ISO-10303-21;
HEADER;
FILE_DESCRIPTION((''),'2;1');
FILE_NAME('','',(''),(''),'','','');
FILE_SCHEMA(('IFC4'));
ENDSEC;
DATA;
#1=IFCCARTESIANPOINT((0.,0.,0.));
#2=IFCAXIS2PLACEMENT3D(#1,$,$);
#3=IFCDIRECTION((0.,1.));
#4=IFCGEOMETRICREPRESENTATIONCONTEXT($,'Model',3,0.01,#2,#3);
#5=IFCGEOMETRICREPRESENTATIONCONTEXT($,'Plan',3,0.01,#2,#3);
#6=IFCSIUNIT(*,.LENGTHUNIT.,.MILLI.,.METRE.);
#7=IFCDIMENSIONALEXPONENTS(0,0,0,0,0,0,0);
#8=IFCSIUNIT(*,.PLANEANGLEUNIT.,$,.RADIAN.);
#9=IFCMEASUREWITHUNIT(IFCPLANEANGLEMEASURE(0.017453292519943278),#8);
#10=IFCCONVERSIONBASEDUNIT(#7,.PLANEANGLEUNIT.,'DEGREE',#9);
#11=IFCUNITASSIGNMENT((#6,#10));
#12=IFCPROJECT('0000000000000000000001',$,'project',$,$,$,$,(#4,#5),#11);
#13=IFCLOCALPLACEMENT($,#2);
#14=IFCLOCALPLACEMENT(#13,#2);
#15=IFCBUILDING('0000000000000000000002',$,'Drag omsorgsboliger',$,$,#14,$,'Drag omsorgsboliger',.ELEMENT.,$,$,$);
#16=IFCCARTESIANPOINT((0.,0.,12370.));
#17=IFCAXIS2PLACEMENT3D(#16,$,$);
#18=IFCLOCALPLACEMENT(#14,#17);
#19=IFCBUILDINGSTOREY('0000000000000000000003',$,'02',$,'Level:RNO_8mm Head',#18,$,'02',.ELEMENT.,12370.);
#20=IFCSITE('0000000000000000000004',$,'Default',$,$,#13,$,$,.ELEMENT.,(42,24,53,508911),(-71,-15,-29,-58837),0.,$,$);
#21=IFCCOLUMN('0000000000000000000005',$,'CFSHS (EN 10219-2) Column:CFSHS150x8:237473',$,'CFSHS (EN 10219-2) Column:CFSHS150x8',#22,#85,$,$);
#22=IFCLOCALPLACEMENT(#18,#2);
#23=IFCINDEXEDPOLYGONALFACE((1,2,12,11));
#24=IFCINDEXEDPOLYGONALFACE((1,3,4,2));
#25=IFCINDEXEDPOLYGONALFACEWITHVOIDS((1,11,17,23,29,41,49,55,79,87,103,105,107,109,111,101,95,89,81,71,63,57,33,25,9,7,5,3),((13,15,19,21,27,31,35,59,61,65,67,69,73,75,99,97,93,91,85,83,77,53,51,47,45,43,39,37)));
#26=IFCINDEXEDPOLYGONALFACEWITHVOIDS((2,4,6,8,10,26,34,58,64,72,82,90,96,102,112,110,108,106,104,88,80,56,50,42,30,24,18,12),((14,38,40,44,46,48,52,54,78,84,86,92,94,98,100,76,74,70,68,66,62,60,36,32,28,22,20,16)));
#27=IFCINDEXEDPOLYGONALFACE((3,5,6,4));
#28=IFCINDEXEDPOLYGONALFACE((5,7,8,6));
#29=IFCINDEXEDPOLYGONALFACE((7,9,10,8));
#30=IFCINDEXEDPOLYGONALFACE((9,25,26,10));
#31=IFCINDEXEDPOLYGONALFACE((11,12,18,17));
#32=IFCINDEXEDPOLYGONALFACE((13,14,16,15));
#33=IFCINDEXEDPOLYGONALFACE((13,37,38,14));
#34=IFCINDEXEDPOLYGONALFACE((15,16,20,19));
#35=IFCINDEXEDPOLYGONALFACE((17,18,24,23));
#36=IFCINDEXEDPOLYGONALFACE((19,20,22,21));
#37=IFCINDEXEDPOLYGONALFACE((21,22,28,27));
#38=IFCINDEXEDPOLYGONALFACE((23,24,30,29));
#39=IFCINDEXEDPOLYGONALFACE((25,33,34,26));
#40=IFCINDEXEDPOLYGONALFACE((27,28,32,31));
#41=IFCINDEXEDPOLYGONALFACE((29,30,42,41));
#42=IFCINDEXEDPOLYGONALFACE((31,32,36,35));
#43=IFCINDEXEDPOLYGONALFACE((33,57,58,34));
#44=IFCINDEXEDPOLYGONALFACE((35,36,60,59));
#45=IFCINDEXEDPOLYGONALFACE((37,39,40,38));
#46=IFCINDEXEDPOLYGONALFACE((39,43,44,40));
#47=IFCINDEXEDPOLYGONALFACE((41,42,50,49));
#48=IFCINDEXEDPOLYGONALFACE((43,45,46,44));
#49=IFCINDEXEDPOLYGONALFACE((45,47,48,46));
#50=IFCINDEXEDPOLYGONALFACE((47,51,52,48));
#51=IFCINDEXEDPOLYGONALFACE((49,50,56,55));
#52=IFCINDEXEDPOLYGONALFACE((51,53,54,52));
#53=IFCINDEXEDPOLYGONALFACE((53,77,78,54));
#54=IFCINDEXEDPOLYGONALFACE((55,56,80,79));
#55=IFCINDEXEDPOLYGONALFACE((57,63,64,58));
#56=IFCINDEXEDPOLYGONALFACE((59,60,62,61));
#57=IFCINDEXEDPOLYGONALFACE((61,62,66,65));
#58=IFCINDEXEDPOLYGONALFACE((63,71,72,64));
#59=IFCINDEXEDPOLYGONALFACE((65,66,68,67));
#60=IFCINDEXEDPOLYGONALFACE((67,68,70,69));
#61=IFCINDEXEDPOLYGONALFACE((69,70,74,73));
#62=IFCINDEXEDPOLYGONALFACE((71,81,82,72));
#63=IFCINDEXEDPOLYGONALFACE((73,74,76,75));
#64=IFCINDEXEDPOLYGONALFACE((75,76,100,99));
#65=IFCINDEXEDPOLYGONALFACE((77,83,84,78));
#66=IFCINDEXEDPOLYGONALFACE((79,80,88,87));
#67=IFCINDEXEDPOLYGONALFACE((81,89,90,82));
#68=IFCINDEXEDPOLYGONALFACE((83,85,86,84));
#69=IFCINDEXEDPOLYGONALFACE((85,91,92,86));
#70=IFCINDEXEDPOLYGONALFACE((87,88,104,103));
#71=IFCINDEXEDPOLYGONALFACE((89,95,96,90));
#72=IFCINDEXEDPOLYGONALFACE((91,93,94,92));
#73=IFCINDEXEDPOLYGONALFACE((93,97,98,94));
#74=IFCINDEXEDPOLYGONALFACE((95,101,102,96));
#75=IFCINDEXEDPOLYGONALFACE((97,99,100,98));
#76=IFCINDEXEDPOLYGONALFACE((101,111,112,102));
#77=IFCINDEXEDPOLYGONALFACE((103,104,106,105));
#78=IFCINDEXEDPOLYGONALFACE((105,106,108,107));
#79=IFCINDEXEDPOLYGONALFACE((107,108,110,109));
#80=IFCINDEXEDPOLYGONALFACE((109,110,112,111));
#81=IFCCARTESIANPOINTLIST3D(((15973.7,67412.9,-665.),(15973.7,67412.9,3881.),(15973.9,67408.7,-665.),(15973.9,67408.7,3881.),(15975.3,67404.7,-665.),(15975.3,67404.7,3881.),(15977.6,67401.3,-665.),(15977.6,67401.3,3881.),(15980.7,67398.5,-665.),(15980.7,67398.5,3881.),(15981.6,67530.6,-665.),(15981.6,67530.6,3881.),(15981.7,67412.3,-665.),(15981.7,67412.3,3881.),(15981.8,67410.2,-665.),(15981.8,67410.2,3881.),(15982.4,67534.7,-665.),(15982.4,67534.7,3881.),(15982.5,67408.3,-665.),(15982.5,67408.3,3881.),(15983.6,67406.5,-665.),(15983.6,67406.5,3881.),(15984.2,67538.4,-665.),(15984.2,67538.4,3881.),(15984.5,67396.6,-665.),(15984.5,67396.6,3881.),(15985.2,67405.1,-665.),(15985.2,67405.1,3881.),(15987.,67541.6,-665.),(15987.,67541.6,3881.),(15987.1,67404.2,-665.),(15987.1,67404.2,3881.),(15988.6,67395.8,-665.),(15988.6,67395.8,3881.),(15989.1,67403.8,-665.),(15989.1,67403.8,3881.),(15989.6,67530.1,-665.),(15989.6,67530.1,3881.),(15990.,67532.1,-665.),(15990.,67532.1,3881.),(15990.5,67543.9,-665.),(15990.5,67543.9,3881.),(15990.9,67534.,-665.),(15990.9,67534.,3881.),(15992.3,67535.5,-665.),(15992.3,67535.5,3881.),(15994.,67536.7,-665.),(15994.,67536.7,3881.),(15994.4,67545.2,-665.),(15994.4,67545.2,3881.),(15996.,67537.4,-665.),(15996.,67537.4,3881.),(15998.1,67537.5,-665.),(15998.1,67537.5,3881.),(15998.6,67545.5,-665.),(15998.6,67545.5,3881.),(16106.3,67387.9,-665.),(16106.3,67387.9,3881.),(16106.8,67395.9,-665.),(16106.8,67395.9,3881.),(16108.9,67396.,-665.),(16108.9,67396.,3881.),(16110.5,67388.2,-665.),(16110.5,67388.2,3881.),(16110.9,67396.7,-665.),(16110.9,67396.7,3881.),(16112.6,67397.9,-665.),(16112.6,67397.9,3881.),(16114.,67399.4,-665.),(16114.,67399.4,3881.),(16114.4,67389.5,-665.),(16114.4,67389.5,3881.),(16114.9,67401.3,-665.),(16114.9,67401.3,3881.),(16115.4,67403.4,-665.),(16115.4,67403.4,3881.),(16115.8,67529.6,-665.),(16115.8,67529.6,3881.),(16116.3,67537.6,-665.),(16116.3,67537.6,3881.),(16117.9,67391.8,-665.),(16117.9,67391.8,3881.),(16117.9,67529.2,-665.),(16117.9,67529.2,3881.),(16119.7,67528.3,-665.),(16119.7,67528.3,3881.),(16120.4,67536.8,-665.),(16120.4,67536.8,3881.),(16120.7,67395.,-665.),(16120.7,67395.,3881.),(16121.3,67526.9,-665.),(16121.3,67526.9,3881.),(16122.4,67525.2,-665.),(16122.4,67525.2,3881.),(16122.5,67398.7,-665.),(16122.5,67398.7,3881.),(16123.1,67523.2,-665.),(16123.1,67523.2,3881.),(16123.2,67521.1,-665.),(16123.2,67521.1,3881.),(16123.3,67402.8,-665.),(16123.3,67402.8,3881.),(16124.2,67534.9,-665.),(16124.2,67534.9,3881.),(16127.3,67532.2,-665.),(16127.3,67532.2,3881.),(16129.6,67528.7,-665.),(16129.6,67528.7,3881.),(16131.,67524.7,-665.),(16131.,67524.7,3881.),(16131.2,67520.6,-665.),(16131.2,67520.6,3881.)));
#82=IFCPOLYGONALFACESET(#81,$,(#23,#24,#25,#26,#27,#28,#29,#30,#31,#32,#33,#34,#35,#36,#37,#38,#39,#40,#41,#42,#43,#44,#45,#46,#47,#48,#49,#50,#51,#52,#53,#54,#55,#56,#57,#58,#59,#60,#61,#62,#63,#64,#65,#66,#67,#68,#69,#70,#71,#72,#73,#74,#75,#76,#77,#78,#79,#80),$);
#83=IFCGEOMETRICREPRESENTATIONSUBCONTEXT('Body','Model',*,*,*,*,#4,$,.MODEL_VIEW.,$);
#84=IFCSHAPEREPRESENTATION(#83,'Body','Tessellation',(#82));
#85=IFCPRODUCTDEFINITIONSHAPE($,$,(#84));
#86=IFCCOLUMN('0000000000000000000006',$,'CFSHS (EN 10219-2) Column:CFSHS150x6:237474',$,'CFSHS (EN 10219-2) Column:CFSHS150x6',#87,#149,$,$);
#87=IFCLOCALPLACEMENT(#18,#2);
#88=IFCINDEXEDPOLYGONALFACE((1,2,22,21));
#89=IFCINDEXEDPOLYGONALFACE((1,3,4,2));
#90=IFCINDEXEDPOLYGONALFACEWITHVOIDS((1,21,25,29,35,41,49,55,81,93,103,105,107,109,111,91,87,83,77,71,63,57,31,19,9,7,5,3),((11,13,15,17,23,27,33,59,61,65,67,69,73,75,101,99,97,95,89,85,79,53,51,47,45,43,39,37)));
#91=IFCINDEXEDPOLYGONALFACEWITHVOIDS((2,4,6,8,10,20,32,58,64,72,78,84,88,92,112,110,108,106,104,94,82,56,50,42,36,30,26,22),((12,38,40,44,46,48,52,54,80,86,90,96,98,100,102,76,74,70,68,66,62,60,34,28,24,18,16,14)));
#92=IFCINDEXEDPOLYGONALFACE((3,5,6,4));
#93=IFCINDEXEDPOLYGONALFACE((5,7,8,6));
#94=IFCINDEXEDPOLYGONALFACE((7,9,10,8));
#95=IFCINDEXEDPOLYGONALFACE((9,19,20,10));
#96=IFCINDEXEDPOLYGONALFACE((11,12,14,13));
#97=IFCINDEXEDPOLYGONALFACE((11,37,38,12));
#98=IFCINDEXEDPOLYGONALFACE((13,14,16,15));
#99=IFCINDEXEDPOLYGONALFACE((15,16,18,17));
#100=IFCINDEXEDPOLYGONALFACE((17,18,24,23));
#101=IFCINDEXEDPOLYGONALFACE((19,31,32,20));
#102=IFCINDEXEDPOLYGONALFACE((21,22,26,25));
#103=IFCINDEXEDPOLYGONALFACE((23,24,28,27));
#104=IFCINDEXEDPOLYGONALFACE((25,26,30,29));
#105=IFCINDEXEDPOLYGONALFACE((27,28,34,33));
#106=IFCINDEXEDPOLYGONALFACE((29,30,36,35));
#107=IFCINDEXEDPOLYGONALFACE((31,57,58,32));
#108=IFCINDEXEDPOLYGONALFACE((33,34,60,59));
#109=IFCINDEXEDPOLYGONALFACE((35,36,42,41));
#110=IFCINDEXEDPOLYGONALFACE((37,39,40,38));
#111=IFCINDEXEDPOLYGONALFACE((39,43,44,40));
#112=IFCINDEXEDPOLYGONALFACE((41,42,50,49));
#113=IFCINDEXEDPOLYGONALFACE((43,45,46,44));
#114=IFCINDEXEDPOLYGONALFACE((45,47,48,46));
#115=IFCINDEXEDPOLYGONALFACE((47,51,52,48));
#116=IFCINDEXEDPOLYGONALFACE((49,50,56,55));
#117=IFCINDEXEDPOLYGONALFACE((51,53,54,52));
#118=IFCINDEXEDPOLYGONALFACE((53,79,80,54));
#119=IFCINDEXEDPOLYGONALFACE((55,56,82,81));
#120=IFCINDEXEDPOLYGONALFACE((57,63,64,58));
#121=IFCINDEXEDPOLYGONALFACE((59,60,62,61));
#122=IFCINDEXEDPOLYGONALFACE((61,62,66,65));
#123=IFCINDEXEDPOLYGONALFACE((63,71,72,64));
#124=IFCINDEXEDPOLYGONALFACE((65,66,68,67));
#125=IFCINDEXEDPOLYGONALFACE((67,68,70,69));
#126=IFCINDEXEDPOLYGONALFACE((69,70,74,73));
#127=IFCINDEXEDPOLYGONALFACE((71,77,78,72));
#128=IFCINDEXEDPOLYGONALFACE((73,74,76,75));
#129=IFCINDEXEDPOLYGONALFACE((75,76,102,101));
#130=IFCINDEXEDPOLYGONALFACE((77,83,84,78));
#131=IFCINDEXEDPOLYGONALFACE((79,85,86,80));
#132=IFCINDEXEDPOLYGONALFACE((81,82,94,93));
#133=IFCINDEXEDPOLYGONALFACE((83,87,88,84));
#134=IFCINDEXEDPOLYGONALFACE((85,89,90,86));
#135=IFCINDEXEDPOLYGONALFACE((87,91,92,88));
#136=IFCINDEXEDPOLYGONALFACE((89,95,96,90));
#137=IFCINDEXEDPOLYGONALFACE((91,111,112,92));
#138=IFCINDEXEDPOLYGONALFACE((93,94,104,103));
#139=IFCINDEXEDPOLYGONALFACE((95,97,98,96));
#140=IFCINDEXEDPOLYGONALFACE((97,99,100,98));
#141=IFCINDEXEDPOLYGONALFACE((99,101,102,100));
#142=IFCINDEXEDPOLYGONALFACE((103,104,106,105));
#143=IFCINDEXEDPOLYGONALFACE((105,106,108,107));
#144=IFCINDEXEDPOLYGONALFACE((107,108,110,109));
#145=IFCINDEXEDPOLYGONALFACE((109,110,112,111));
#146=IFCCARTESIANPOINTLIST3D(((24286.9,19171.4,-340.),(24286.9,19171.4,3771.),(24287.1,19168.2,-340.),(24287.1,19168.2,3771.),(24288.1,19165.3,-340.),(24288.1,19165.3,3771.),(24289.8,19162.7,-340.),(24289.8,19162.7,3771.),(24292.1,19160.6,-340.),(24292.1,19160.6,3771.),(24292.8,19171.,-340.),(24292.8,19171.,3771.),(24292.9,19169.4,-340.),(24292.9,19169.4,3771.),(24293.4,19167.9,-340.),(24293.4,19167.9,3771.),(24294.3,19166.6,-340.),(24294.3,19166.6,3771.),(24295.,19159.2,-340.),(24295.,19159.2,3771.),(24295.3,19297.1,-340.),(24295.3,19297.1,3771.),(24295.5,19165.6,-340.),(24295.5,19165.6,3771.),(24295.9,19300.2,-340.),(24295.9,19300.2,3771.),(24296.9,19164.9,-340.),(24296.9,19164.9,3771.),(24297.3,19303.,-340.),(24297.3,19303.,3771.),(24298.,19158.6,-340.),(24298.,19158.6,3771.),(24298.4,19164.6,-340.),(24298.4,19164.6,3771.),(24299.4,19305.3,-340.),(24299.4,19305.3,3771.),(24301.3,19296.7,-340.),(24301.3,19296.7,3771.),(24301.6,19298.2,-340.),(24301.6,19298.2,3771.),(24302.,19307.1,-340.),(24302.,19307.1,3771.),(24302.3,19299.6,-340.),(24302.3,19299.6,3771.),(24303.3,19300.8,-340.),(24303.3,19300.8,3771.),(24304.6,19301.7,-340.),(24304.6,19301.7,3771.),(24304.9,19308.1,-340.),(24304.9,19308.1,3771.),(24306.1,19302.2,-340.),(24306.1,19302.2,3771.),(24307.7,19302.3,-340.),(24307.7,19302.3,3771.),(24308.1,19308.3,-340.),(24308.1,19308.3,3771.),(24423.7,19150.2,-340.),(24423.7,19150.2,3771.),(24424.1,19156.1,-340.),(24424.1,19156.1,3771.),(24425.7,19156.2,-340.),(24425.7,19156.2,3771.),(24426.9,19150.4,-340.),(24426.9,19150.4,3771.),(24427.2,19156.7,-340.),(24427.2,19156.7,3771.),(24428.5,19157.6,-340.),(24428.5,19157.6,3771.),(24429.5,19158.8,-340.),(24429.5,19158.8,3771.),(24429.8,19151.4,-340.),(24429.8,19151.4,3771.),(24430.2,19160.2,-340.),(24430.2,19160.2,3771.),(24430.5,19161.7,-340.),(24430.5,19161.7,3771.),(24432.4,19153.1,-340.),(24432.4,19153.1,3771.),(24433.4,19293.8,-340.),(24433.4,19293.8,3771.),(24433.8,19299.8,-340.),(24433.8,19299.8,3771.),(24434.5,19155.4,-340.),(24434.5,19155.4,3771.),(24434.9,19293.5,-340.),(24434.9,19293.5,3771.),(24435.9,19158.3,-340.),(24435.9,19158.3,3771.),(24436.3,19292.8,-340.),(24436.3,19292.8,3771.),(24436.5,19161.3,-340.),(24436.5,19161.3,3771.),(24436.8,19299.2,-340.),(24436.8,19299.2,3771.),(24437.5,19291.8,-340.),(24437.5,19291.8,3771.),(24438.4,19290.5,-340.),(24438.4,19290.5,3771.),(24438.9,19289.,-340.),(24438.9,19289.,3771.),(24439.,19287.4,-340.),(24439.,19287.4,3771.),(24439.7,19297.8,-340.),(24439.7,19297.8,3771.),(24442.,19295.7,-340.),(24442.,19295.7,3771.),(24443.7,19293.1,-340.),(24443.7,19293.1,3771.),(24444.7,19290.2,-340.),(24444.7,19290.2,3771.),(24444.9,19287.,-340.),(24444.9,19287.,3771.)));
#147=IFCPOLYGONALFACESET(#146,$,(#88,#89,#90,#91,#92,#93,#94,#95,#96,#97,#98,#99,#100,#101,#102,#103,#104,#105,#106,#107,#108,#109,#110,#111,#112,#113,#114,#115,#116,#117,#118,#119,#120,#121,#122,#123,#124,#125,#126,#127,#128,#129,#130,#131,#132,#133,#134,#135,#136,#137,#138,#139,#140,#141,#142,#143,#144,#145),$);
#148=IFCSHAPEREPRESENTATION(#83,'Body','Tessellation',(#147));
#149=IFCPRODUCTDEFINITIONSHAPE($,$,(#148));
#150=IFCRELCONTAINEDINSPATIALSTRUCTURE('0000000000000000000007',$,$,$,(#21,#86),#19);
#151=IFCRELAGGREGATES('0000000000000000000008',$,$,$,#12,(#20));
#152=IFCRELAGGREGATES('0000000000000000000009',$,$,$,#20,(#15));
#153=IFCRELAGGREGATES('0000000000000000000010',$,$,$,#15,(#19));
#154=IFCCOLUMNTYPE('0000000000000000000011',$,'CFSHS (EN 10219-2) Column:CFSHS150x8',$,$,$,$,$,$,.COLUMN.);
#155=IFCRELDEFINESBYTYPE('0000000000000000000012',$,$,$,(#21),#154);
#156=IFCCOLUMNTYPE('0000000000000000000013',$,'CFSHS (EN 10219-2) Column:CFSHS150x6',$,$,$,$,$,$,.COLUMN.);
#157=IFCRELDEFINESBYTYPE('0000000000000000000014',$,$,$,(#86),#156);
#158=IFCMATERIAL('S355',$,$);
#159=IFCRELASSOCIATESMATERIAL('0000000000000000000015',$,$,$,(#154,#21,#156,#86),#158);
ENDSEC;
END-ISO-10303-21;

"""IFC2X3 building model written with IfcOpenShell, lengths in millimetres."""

from ifc_helpers import new_model, entity, si_unit, converted_unit, direction, frame, frame_2d, origin, place, context, subcontext, project, spatial, polyline, circle_curve, parameter, trimmed, segment, composite_curve, outline, extrude, source, transform, mapped, material, type_object, type_shapes, element, save


model = new_model("IFC2X3")

# Units and contexts
model_context = context("Model", 3, precision=0.01, world=origin(), true_north=direction((0.0, 1.0)))
plan_context = context("Plan", 3, precision=0.01, world=origin(), true_north=direction((0.0, 1.0)))
body_context = subcontext(model_context, "Body", "Model", "MODEL_VIEW")
ifc_project = project(units=[si_unit("LENGTHUNIT", "METRE", prefix="MILLI"), converted_unit("PLANEANGLEUNIT", "DEGREE", entity("IfcPlaneAngleMeasure", 0.017453292519943278), si_unit("PLANEANGLEUNIT", "RADIAN"), dimensions=[0, 0, 0, 0, 0, 0, 0])], contexts=[model_context, plan_context])

# Site, building, storey
site_placement = place(None, origin())
site = spatial("IfcSite", under=ifc_project, at=site_placement, Name="Default", CompositionType="ELEMENT", RefLatitude=(42, 24, 53, 508911), RefLongitude=(-71, -15, -29, -58837), RefElevation=0.0)
building_placement = place(site_placement, origin())
building = spatial("IfcBuilding", under=site, at=building_placement, Name="Drag omsorgsboliger", LongName="Drag omsorgsboliger", CompositionType="ELEMENT")
storey_placement = place(building_placement, frame((0.0, 0.0, 12370.0)))
storey = spatial("IfcBuildingStorey", under=building, at=storey_placement, Name="02", ObjectType="Level:RNO_8mm Head", LongName="02", CompositionType="ELEMENT", Elevation=12370.0)

# Columns
ifc_material = material(Name="S355")
column_type_1 = type_object("IfcColumnType", Name="CFSHS (EN 10219-2) Column:CFSHS150x8", PredefinedType="COLUMN", material=ifc_material)
shared_shape_1 = source(origin(), body_context, "Body", "SweptSolid", [
    extrude(outline(composite_curve([segment(polyline([(-59.0, -75.0), (59.0, -75.0)]), True, "CONTINUOUS"), segment(trimmed(circle_curve(frame_2d((59.0, -59.0), x_axis=(-1.0, 0.0)), 16.0), [parameter(90.0)], [parameter(180.0)], True, "PARAMETER"), True, "CONTINUOUS"), segment(polyline([(75.0, -59.0), (75.0, 59.0)]), True, "CONTINUOUS"), segment(trimmed(circle_curve(frame_2d((59.0, 59.0), x_axis=(-1.0, 0.0)), 16.0), [parameter(180.0)], [parameter(270.0)], True, "PARAMETER"), True, "CONTINUOUS"), segment(polyline([(59.0, 75.0), (-59.0, 75.0)]), True, "CONTINUOUS"), segment(trimmed(circle_curve(frame_2d((-59.0, 59.0), x_axis=(-1.0, 0.0)), 16.0), [parameter(270.0)], [parameter(360.0)], True, "PARAMETER"), True, "CONTINUOUS"), segment(polyline([(-75.0, 59.0), (-75.0, -59.0)]), True, "CONTINUOUS"), segment(trimmed(circle_curve(frame_2d((-59.0, -59.0), x_axis=(-1.0, 0.0)), 16.0), [parameter(360.0)], [parameter(90.0)], True, "PARAMETER"), True, "CONTINUOUS")], self_intersect=False), holes=[composite_curve([segment(trimmed(circle_curve(frame_2d((-59.0, -59.0), x_axis=(-1.0, 0.0)), 8.0), [parameter(360.0)], [parameter(90.0)], True, "PARAMETER"), False, "CONTINUOUS"), segment(polyline([(-67.0, -59.0), (-67.0, 59.0)]), True, "CONTINUOUS"), segment(trimmed(circle_curve(frame_2d((-59.0, 59.0), x_axis=(-1.0, 0.0)), 8.0), [parameter(270.0)], [parameter(360.0)], True, "PARAMETER"), False, "CONTINUOUS"), segment(polyline([(-59.0, 67.0), (59.0, 67.0)]), True, "CONTINUOUS"), segment(trimmed(circle_curve(frame_2d((59.0, 59.0), x_axis=(-1.0, 0.0)), 8.0), [parameter(180.0)], [parameter(270.0)], True, "PARAMETER"), False, "CONTINUOUS"), segment(polyline([(67.0, 59.0), (67.0, -59.0)]), True, "CONTINUOUS"), segment(trimmed(circle_curve(frame_2d((59.0, -59.0), x_axis=(-1.0, 0.0)), 8.0), [parameter(90.0)], [parameter(180.0)], True, "PARAMETER"), False, "CONTINUOUS"), segment(polyline([(59.0, -67.0), (-59.0, -67.0)]), True, "CONTINUOUS")], self_intersect=False)]), frame((16052.5, 67466.7, 11705.0), z_axis=(0.0, 0.0, 1.0), x_axis=(-0.997758, 0.066923, 0.0)), (0.0, 0.0, 1.0), 4546.0),
])
type_shapes(column_type_1, [shared_shape_1])
column_1_placement = place(storey_placement, frame((0.0, 0.0, -12370.0)))
element("IfcColumn", 1, at=column_1_placement, inside=storey, type_object=column_type_1, material=ifc_material, Name="CFSHS (EN 10219-2) Column:CFSHS150x8:237473", ObjectType="CFSHS (EN 10219-2) Column:CFSHS150x8", context=body_context, shape_type="MappedRepresentation", body=[
    mapped(shared_shape_1, transform((0.0, 0.0, 0.0), scale=1.0)),
])
column_type_2 = type_object("IfcColumnType", Name="CFSHS (EN 10219-2) Column:CFSHS150x6", PredefinedType="COLUMN", material=ifc_material)
shared_shape_2 = source(origin(), body_context, "Body", "SweptSolid", [
    extrude(outline(composite_curve([segment(polyline([(-63.0, -75.0), (63.0, -75.0)]), True, "CONTINUOUS"), segment(trimmed(circle_curve(frame_2d((63.0, -63.0), x_axis=(-1.0, 0.0)), 12.0), [parameter(90.0)], [parameter(180.0)], True, "PARAMETER"), True, "CONTINUOUS"), segment(polyline([(75.0, -63.0), (75.0, 63.0)]), True, "CONTINUOUS"), segment(trimmed(circle_curve(frame_2d((63.0, 63.0), x_axis=(-1.0, 0.0)), 12.0), [parameter(180.0)], [parameter(270.0)], True, "PARAMETER"), True, "CONTINUOUS"), segment(polyline([(63.0, 75.0), (-63.0, 75.0)]), True, "CONTINUOUS"), segment(trimmed(circle_curve(frame_2d((-63.0, 63.0), x_axis=(-1.0, 0.0)), 12.0), [parameter(270.0)], [parameter(360.0)], True, "PARAMETER"), True, "CONTINUOUS"), segment(polyline([(-75.0, 63.0), (-75.0, -63.0)]), True, "CONTINUOUS"), segment(trimmed(circle_curve(frame_2d((-63.0, -63.0), x_axis=(-1.0, 0.0)), 12.0), [parameter(360.0)], [parameter(90.0)], True, "PARAMETER"), True, "CONTINUOUS")], self_intersect=False), holes=[composite_curve([segment(trimmed(circle_curve(frame_2d((-63.0, -63.0), x_axis=(-1.0, 0.0)), 6.0), [parameter(360.0)], [parameter(90.0)], True, "PARAMETER"), False, "CONTINUOUS"), segment(polyline([(-69.0, -63.0), (-69.0, 63.0)]), True, "CONTINUOUS"), segment(trimmed(circle_curve(frame_2d((-63.0, 63.0), x_axis=(-1.0, 0.0)), 6.0), [parameter(270.0)], [parameter(360.0)], True, "PARAMETER"), False, "CONTINUOUS"), segment(polyline([(-63.0, 69.0), (63.0, 69.0)]), True, "CONTINUOUS"), segment(trimmed(circle_curve(frame_2d((63.0, 63.0), x_axis=(-1.0, 0.0)), 6.0), [parameter(180.0)], [parameter(270.0)], True, "PARAMETER"), False, "CONTINUOUS"), segment(polyline([(69.0, 63.0), (69.0, -63.0)]), True, "CONTINUOUS"), segment(trimmed(circle_curve(frame_2d((63.0, -63.0), x_axis=(-1.0, 0.0)), 6.0), [parameter(90.0)], [parameter(180.0)], True, "PARAMETER"), False, "CONTINUOUS"), segment(polyline([(63.0, -69.0), (-63.0, -69.0)]), True, "CONTINUOUS")], self_intersect=False)]), frame((24365.9, 19229.2, 12030.0), z_axis=(0.0, 0.0, 1.0), x_axis=(-0.997758, 0.066923, 0.0)), (0.0, 0.0, 1.0), 4111.0),
])
type_shapes(column_type_2, [shared_shape_2])
column_2_placement = place(storey_placement, frame((0.0, 0.0, -12370.0)))
element("IfcColumn", 2, at=column_2_placement, inside=storey, type_object=column_type_2, material=ifc_material, Name="CFSHS (EN 10219-2) Column:CFSHS150x6:237474", ObjectType="CFSHS (EN 10219-2) Column:CFSHS150x6", context=body_context, shape_type="MappedRepresentation", body=[
    mapped(shared_shape_2, transform((0.0, 0.0, 0.0), scale=1.0)),
])

save(model, "model.ifc")
